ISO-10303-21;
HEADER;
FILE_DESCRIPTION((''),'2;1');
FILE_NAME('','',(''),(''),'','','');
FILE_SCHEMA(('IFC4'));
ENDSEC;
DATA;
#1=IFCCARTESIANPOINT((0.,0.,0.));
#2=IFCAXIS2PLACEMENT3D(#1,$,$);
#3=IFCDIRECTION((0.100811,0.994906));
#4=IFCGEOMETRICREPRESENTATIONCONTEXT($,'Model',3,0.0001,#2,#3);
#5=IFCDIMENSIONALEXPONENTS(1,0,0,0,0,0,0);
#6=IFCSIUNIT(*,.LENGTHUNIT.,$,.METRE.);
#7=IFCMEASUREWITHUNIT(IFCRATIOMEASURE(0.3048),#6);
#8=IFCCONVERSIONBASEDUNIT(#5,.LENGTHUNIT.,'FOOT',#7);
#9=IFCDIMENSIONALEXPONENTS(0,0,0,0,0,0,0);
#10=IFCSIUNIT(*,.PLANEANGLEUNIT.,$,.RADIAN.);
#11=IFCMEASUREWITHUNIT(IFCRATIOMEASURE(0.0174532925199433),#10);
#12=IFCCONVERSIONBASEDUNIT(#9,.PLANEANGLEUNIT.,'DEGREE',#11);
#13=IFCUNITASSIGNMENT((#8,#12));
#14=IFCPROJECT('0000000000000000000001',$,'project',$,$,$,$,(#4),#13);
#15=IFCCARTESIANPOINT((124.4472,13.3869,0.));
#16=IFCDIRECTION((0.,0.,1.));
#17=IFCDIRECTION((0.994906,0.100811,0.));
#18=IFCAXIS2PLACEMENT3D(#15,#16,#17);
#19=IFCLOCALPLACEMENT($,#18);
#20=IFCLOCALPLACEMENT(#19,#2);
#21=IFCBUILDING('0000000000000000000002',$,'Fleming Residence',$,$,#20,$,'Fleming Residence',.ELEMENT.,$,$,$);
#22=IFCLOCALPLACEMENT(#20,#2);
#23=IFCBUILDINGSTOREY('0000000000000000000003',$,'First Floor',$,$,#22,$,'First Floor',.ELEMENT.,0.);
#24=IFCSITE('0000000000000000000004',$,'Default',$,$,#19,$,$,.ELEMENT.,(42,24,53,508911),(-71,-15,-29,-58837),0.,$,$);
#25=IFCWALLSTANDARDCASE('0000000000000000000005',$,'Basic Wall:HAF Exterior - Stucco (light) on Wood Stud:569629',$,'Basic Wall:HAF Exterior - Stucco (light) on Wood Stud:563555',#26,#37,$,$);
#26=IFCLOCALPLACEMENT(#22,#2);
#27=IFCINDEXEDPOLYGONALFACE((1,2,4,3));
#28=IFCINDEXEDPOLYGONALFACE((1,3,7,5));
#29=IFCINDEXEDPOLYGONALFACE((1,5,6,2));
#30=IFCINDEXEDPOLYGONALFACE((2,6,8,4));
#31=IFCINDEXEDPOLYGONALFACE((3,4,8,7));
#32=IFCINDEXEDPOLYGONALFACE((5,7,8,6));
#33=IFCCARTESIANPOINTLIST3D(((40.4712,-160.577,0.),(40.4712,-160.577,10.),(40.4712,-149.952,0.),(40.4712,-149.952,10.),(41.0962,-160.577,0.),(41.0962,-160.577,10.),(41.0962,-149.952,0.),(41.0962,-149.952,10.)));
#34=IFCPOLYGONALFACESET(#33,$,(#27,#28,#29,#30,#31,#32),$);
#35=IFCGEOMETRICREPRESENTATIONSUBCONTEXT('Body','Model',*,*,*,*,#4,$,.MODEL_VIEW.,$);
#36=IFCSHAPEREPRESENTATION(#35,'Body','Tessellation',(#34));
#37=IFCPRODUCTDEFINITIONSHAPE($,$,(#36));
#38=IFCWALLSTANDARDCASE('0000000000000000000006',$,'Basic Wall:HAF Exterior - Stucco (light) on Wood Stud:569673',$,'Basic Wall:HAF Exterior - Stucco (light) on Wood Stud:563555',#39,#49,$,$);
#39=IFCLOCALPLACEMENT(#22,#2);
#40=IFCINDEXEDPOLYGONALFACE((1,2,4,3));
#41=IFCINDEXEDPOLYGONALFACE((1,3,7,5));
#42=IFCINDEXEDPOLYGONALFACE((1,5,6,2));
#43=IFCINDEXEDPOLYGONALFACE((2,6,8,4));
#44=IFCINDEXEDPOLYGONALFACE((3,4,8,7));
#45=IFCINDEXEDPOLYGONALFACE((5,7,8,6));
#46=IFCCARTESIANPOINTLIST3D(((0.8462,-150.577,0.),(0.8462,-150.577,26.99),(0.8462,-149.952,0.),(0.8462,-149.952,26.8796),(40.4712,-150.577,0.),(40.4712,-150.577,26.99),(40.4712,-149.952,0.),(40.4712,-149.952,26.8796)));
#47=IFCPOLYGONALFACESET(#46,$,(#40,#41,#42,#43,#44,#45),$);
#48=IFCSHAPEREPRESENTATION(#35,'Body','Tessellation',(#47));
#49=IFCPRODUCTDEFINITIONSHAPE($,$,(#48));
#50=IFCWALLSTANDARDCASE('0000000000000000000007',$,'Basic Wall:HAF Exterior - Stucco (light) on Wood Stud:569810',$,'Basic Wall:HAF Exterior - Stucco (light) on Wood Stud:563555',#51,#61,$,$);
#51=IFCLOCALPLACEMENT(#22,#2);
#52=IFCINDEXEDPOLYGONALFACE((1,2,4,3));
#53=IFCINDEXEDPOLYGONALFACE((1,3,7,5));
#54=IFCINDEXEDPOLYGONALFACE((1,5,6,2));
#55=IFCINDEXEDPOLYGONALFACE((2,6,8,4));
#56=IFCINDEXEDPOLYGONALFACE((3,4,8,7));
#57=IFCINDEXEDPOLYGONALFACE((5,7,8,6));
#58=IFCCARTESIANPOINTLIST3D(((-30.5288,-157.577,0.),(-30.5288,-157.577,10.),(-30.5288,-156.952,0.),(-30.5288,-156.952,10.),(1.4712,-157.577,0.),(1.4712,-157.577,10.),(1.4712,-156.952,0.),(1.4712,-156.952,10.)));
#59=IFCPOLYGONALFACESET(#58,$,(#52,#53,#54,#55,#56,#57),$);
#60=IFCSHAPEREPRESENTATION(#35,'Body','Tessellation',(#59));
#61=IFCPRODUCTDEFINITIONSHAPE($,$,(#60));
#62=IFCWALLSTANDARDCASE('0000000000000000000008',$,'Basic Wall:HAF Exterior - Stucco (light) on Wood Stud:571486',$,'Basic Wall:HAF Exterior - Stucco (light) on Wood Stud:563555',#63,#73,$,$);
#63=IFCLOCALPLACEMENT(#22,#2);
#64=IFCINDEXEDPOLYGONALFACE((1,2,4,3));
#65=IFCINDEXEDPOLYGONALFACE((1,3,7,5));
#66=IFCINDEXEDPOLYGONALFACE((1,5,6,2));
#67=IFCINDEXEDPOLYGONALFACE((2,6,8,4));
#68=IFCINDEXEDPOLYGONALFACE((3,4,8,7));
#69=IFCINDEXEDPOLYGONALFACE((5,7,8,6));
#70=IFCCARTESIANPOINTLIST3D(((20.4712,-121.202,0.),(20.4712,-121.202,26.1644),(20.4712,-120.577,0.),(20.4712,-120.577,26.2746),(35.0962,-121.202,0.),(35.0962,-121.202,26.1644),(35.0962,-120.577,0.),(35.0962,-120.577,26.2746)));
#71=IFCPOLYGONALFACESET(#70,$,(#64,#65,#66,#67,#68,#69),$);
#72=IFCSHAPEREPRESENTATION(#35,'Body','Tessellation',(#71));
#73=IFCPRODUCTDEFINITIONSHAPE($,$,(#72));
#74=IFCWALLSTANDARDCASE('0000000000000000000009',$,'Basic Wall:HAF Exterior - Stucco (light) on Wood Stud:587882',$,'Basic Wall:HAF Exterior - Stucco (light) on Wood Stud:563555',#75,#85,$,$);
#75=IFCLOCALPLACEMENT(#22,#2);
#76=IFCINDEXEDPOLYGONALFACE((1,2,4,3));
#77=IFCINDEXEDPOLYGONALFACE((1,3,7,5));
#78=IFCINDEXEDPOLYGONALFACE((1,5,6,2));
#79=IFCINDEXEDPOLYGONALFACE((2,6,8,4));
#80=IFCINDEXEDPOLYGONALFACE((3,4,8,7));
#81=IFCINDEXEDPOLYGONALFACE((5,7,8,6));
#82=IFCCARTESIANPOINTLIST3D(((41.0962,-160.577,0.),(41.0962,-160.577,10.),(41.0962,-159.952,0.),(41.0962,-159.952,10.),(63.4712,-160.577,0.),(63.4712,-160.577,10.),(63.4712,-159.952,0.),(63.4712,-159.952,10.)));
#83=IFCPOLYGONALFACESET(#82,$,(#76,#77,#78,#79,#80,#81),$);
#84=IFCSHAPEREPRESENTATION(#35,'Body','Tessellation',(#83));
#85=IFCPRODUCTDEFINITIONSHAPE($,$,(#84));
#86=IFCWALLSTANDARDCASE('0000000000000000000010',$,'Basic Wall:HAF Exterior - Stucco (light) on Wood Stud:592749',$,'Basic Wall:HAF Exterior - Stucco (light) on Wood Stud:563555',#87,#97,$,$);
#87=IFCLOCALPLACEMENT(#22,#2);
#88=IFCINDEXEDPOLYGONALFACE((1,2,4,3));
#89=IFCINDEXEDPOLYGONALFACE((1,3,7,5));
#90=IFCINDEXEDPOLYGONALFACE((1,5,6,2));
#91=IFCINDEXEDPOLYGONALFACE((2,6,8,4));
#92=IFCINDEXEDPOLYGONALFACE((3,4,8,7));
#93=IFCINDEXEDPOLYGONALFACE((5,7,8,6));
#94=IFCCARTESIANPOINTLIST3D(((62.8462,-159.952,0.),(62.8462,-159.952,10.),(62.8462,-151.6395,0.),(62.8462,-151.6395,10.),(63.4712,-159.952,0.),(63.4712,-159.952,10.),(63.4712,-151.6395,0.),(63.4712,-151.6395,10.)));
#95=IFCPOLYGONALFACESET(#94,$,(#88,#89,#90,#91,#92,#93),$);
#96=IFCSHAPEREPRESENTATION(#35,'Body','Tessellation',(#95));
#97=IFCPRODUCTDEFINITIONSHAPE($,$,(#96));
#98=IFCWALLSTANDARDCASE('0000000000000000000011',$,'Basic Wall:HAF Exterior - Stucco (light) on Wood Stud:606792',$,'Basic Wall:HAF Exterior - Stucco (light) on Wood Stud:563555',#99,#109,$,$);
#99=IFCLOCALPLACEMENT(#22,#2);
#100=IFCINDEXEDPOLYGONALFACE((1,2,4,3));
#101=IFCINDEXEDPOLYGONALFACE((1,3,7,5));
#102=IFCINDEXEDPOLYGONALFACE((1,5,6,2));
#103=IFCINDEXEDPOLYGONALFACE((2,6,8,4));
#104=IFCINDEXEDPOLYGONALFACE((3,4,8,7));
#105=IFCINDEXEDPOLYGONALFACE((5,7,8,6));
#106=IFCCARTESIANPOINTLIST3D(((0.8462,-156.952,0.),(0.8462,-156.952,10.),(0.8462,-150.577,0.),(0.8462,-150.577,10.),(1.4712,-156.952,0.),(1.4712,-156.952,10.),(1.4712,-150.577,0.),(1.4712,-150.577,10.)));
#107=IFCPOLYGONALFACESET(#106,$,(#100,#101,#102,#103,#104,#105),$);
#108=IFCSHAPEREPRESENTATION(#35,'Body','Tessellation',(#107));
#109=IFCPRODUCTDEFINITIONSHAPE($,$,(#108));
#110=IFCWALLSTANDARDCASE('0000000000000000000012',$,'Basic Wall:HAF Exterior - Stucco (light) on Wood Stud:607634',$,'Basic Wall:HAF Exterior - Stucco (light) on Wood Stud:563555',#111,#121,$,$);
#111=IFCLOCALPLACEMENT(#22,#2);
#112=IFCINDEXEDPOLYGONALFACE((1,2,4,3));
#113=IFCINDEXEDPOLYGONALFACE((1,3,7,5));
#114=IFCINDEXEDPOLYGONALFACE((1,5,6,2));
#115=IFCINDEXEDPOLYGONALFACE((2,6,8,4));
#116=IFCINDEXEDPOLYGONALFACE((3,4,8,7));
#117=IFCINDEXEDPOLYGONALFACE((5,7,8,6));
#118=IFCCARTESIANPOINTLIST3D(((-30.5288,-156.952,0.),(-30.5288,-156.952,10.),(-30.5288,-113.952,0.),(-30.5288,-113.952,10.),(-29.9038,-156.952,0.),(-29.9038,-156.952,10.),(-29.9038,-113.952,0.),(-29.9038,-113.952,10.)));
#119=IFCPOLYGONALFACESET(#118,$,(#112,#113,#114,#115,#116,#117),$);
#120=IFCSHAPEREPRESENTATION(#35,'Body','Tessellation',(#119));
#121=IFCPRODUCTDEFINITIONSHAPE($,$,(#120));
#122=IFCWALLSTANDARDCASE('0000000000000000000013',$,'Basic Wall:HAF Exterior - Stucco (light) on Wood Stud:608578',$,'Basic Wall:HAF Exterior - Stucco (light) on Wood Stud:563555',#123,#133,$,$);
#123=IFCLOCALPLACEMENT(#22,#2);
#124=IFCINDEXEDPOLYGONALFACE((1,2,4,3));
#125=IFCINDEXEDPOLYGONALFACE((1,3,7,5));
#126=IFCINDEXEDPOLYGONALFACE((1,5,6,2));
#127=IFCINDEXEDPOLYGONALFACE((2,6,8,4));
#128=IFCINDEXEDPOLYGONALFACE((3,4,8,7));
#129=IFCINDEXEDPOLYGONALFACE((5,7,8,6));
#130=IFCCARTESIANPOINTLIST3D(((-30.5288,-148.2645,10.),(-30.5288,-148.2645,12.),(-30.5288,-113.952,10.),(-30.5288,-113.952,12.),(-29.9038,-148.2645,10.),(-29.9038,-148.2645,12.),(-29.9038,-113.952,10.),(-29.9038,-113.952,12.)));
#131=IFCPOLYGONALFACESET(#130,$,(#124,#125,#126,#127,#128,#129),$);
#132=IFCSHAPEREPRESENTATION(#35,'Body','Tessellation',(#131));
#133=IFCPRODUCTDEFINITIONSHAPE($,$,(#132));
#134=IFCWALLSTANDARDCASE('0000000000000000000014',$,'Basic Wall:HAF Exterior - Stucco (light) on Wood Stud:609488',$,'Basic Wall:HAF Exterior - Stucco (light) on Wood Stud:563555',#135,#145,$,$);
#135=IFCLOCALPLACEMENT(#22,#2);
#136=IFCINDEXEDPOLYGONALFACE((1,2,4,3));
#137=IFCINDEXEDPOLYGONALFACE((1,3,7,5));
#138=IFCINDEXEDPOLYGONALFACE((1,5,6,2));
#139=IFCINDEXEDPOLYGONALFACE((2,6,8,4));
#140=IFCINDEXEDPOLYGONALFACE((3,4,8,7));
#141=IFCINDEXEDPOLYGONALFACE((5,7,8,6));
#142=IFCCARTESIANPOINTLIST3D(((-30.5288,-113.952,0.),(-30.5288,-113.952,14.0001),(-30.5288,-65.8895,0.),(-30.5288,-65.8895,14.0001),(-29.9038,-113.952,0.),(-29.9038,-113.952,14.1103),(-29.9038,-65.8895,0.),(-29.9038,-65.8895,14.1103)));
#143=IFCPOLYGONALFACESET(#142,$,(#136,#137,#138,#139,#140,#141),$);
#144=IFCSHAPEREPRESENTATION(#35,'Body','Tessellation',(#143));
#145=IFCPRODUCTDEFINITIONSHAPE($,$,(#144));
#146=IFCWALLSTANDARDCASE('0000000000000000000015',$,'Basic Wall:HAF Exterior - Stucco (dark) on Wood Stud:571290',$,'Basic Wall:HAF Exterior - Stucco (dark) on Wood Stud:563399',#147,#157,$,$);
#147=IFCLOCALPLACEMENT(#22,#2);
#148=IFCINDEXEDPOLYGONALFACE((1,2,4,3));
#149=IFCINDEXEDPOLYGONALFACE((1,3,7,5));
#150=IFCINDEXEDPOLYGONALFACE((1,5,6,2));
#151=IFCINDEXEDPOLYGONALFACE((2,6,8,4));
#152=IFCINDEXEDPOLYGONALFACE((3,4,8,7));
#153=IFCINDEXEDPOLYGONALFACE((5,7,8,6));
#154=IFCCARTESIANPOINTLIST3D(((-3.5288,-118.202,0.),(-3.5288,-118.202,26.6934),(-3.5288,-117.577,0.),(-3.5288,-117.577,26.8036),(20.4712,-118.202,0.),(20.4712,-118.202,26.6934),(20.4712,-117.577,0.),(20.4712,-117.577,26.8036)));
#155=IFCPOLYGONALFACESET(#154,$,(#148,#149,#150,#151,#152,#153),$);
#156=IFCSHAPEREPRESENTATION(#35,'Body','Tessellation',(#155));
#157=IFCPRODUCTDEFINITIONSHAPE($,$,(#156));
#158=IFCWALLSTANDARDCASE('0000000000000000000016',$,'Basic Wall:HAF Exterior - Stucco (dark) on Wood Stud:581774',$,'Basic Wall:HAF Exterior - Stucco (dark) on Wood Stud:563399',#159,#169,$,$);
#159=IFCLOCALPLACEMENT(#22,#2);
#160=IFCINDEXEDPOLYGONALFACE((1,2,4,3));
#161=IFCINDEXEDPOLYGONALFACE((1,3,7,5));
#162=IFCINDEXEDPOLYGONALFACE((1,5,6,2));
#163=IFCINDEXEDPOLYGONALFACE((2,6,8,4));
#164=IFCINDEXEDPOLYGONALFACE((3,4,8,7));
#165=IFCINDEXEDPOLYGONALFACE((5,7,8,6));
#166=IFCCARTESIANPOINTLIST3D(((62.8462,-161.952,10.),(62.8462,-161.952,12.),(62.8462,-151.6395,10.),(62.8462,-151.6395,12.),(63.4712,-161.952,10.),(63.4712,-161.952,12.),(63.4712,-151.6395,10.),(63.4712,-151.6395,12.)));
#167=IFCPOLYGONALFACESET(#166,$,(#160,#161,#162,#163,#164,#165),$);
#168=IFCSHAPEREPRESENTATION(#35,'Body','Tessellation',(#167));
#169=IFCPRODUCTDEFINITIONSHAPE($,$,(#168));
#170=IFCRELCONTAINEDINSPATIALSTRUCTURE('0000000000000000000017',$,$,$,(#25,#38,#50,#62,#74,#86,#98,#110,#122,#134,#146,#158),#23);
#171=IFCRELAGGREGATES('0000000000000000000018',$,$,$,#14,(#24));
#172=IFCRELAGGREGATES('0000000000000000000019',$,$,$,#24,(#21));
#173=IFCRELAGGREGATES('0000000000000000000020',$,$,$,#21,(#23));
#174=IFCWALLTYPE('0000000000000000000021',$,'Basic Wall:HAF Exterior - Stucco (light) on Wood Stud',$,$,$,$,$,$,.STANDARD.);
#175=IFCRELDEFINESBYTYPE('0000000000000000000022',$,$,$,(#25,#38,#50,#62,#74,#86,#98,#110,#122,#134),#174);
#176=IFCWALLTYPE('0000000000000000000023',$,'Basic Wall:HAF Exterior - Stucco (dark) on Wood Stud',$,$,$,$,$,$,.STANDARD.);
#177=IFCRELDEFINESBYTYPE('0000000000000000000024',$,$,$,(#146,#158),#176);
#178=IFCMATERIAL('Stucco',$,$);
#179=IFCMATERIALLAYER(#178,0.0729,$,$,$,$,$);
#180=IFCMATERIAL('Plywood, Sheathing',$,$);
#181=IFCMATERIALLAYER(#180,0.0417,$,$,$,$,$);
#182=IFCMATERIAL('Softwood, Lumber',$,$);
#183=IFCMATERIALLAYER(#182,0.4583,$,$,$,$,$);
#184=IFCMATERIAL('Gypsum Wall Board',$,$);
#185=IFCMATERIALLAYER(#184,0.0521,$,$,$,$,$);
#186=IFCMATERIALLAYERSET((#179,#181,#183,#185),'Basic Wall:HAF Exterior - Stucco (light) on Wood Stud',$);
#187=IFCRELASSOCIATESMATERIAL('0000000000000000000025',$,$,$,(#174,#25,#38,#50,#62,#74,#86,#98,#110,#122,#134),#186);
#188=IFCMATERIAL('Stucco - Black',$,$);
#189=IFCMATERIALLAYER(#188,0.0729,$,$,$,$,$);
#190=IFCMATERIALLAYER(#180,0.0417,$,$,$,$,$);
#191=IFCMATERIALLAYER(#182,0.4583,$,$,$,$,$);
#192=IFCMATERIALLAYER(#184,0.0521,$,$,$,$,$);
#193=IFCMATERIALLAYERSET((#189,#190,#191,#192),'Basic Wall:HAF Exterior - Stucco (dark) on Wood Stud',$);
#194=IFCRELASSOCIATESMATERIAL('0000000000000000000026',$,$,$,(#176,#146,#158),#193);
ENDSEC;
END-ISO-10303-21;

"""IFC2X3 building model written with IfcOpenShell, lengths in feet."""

from ifc_helpers import new_model, entity, si_unit, converted_unit, direction, frame, frame_2d, origin, place, context, subcontext, project, spatial, polyline, rectangle, extrude, clip, bounded_halfspace, material, layer, layer_set, layer_usage, type_object, element, save


model = new_model("IFC2X3")

# Units and contexts
model_context = context("Model", 3, precision=0.0001, world=origin(), true_north=direction((0.100811, 0.994906)))
body_context = subcontext(model_context, "Body", "Model", "MODEL_VIEW")
ifc_project = project(units=[converted_unit("LENGTHUNIT", "FOOT", entity("IfcRatioMeasure", 0.3048), si_unit("LENGTHUNIT", "METRE"), dimensions=[1, 0, 0, 0, 0, 0, 0]), converted_unit("PLANEANGLEUNIT", "DEGREE", entity("IfcRatioMeasure", 0.0174532925199433), si_unit("PLANEANGLEUNIT", "RADIAN"), dimensions=[0, 0, 0, 0, 0, 0, 0])], contexts=[model_context])

# Site, building, storey
site_placement = place(None, frame((124.4472, 13.3869, 0.0), z_axis=(0.0, 0.0, 1.0), x_axis=(0.994906, 0.100811, 0.0)))
site = spatial("IfcSite", under=ifc_project, at=site_placement, Name="Default", CompositionType="ELEMENT", RefLatitude=(42, 24, 53, 508911), RefLongitude=(-71, -15, -29, -58837), RefElevation=0.0)
building_placement = place(site_placement, origin())
building = spatial("IfcBuilding", under=site, at=building_placement, Name="Fleming Residence", LongName="Fleming Residence", CompositionType="ELEMENT")
storey_placement = place(building_placement, origin())
storey = spatial("IfcBuildingStorey", under=building, at=storey_placement, Name="First Floor", LongName="First Floor", CompositionType="ELEMENT", Elevation=0.0)

# Walls
ifc_material_1 = material(Name="Stucco")
ifc_layer_1 = layer(ifc_material_1, 0.0729)
ifc_material_2 = material(Name="Plywood, Sheathing")
ifc_layer_2 = layer(ifc_material_2, 0.0417)
ifc_material_3 = material(Name="Softwood, Lumber")
ifc_layer_3 = layer(ifc_material_3, 0.4583)
ifc_material_4 = material(Name="Gypsum Wall Board")
ifc_layer_4 = layer(ifc_material_4, 0.0521)
ifc_layer_set_1 = layer_set([ifc_layer_1, ifc_layer_2, ifc_layer_3, ifc_layer_4], Name="Basic Wall:HAF Exterior - Stucco (light) on Wood Stud")
ifc_layer_usage_1 = layer_usage(ifc_layer_set_1, "AXIS2", "NEGATIVE", 0.3125)
wall_type_1 = type_object("IfcWallType", Name="Basic Wall:HAF Exterior - Stucco (light) on Wood Stud", PredefinedType="STANDARD", material=ifc_layer_set_1)
wall_1_placement = place(storey_placement, frame((40.7837, -160.577, 0.0), z_axis=(0.0, 0.0, 1.0), x_axis=(0.0, 1.0, 0.0)))
element("IfcWallStandardCase", 1, at=wall_1_placement, inside=storey, type_object=wall_type_1, material=ifc_layer_usage_1, Name="Basic Wall:HAF Exterior - Stucco (light) on Wood Stud:569629", ObjectType="Basic Wall:HAF Exterior - Stucco (light) on Wood Stud:563555", context=body_context, shape_type="SweptSolid", body=[
    extrude(rectangle(XDim=10.625, YDim=0.625, at=frame_2d((5.3125, 0.0), x_axis=(-1.0, 0.0))), origin(), (0.0, 0.0, 1.0), 10.0),
])
ifc_layer_usage_2 = layer_usage(ifc_layer_set_1, "AXIS2", "NEGATIVE", 0.3125)
wall_2_placement = place(storey_placement, frame((41.0962, -150.2645, 0.0), z_axis=(0.0, 0.0, 1.0), x_axis=(-1.0, 0.0, 0.0)))
element("IfcWallStandardCase", 2, at=wall_2_placement, inside=storey, type_object=wall_type_1, material=ifc_layer_usage_2, Name="Basic Wall:HAF Exterior - Stucco (light) on Wood Stud:569673", ObjectType="Basic Wall:HAF Exterior - Stucco (light) on Wood Stud:563555", context=body_context, shape_type="Clipping", body=[
    clip(extrude(rectangle(XDim=39.625, YDim=0.625, at=frame_2d((20.4375, 0.0), x_axis=(-1.0, 0.0))), origin(), (0.0, 0.0, 1.0), 26.99), bounded_halfspace(frame((0.0, -0.3125, 26.8796), z_axis=(0.0, 0.174064, -0.984734), x_axis=(1.0, 0.0, 0.0)), True, frame((0.0, -0.3125, 26.8796)), polyline([(0.0, 0.0), (39.625, 0.0), (40.25, 0.0), (40.25, 0.625), (0.0, 0.625), (0.0, 0.0)]))),
])
ifc_layer_usage_3 = layer_usage(ifc_layer_set_1, "AXIS2", "NEGATIVE", 0.3125)
wall_3_placement = place(storey_placement, frame((1.4712, -157.2645, 0.0), z_axis=(0.0, 0.0, 1.0), x_axis=(-1.0, 0.0, 0.0)))
element("IfcWallStandardCase", 3, at=wall_3_placement, inside=storey, type_object=wall_type_1, material=ifc_layer_usage_3, Name="Basic Wall:HAF Exterior - Stucco (light) on Wood Stud:569810", ObjectType="Basic Wall:HAF Exterior - Stucco (light) on Wood Stud:563555", context=body_context, shape_type="SweptSolid", body=[
    extrude(rectangle(XDim=32.0, YDim=0.625, at=frame_2d((16.0, 0.0), x_axis=(-1.0, 0.0))), origin(), (0.0, 0.0, 1.0), 10.0),
])
ifc_layer_usage_4 = layer_usage(ifc_layer_set_1, "AXIS2", "NEGATIVE", 0.3125)
wall_4_placement = place(storey_placement, frame((20.4712, -120.8895, 0.0)))
element("IfcWallStandardCase", 4, at=wall_4_placement, inside=storey, type_object=wall_type_1, material=ifc_layer_usage_4, Name="Basic Wall:HAF Exterior - Stucco (light) on Wood Stud:571486", ObjectType="Basic Wall:HAF Exterior - Stucco (light) on Wood Stud:563555", context=body_context, shape_type="Clipping", body=[
    clip(extrude(rectangle(XDim=14.625, YDim=0.625, at=frame_2d((7.3125, 0.0), x_axis=(-1.0, 0.0))), origin(), (0.0, 0.0, 1.0), 26.2746), bounded_halfspace(frame((0.0, -0.3125, 26.1644), z_axis=(0.0, 0.173648, -0.984808), x_axis=(-1.0, 0.0, 0.0)), True, frame((0.0, -0.3125, 26.1644)), polyline([(0.0, 0.0), (14.625, 0.0), (14.625, 0.625), (0.0, 0.625), (0.0, 0.0)]))),
])
ifc_layer_usage_5 = layer_usage(ifc_layer_set_1, "AXIS2", "NEGATIVE", 0.3125)
wall_5_placement = place(storey_placement, frame((63.4712, -160.2645, 0.0), z_axis=(0.0, 0.0, 1.0), x_axis=(-1.0, 0.0, 0.0)))
element("IfcWallStandardCase", 5, at=wall_5_placement, inside=storey, type_object=wall_type_1, material=ifc_layer_usage_5, Name="Basic Wall:HAF Exterior - Stucco (light) on Wood Stud:587882", ObjectType="Basic Wall:HAF Exterior - Stucco (light) on Wood Stud:563555", context=body_context, shape_type="SweptSolid", body=[
    extrude(rectangle(XDim=22.375, YDim=0.625, at=frame_2d((11.1875, 0.0), x_axis=(-1.0, 0.0))), origin(), (0.0, 0.0, 1.0), 10.0),
])
ifc_layer_usage_6 = layer_usage(ifc_layer_set_1, "AXIS2", "NEGATIVE", 0.3125)
wall_6_placement = place(storey_placement, frame((63.1587, -151.6395, 0.0), z_axis=(0.0, 0.0, 1.0), x_axis=(0.0, -1.0, 0.0)))
element("IfcWallStandardCase", 6, at=wall_6_placement, inside=storey, type_object=wall_type_1, material=ifc_layer_usage_6, Name="Basic Wall:HAF Exterior - Stucco (light) on Wood Stud:592749", ObjectType="Basic Wall:HAF Exterior - Stucco (light) on Wood Stud:563555", context=body_context, shape_type="SweptSolid", body=[
    extrude(rectangle(XDim=8.3125, YDim=0.625, at=frame_2d((4.1562, 0.0), x_axis=(-1.0, 0.0))), origin(), (0.0, 0.0, 1.0), 10.0),
])
ifc_layer_usage_7 = layer_usage(ifc_layer_set_1, "AXIS2", "NEGATIVE", 0.3125)
wall_7_placement = place(storey_placement, frame((1.1587, -150.577, 0.0), z_axis=(0.0, 0.0, 1.0), x_axis=(0.0, -1.0, 0.0)))
element("IfcWallStandardCase", 7, at=wall_7_placement, inside=storey, type_object=wall_type_1, material=ifc_layer_usage_7, Name="Basic Wall:HAF Exterior - Stucco (light) on Wood Stud:606792", ObjectType="Basic Wall:HAF Exterior - Stucco (light) on Wood Stud:563555", context=body_context, shape_type="SweptSolid", body=[
    extrude(rectangle(XDim=6.375, YDim=0.625, at=frame_2d((3.1875, 0.0), x_axis=(-1.0, 0.0))), origin(), (0.0, 0.0, 1.0), 10.0),
])
ifc_layer_usage_8 = layer_usage(ifc_layer_set_1, "AXIS2", "NEGATIVE", 0.3125)
wall_8_placement = place(storey_placement, frame((-30.2163, -156.952, 0.0), z_axis=(0.0, 0.0, 1.0), x_axis=(0.0, 1.0, 0.0)))
element("IfcWallStandardCase", 8, at=wall_8_placement, inside=storey, type_object=wall_type_1, material=ifc_layer_usage_8, Name="Basic Wall:HAF Exterior - Stucco (light) on Wood Stud:607634", ObjectType="Basic Wall:HAF Exterior - Stucco (light) on Wood Stud:563555", context=body_context, shape_type="SweptSolid", body=[
    extrude(rectangle(XDim=43.0, YDim=0.625, at=frame_2d((21.5, 0.0), x_axis=(-1.0, 0.0))), origin(), (0.0, 0.0, 1.0), 10.0),
])
ifc_layer_usage_9 = layer_usage(ifc_layer_set_1, "AXIS2", "NEGATIVE", 0.3125)
wall_9_placement = place(storey_placement, frame((-30.2163, -148.2645, 10.0), z_axis=(0.0, 0.0, 1.0), x_axis=(0.0, 1.0, 0.0)))
element("IfcWallStandardCase", 9, at=wall_9_placement, inside=storey, type_object=wall_type_1, material=ifc_layer_usage_9, Name="Basic Wall:HAF Exterior - Stucco (light) on Wood Stud:608578", ObjectType="Basic Wall:HAF Exterior - Stucco (light) on Wood Stud:563555", context=body_context, shape_type="SweptSolid", body=[
    extrude(rectangle(XDim=34.3125, YDim=0.625, at=frame_2d((17.1562, 0.0), x_axis=(-1.0, 0.0))), origin(), (0.0, 0.0, 1.0), 2.0),
])
ifc_layer_usage_10 = layer_usage(ifc_layer_set_1, "AXIS2", "NEGATIVE", 0.3125)
wall_10_placement = place(storey_placement, frame((-30.2163, -113.952, 0.0), z_axis=(0.0, 0.0, 1.0), x_axis=(0.0, 1.0, 0.0)))
element("IfcWallStandardCase", 10, at=wall_10_placement, inside=storey, type_object=wall_type_1, material=ifc_layer_usage_10, Name="Basic Wall:HAF Exterior - Stucco (light) on Wood Stud:609488", ObjectType="Basic Wall:HAF Exterior - Stucco (light) on Wood Stud:563555", context=body_context, shape_type="Clipping", body=[
    clip(extrude(rectangle(XDim=48.0625, YDim=0.625, at=frame_2d((24.0312, 0.0), x_axis=(-1.0, 0.0))), origin(), (0.0, 0.0, 1.0), 14.1103), bounded_halfspace(frame((0.0, -0.3125, 14.1103), z_axis=(0.0, -0.173648, -0.984808), x_axis=(-1.0, 0.0, 0.0)), True, frame((0.0, -0.3125, 14.1103)), polyline([(0.0, 0.0), (48.0625, 0.0), (48.0625, 0.625), (0.0, 0.625), (0.0, 0.0)]))),
])
ifc_material_5 = material(Name="Stucco - Black")
ifc_layer_5 = layer(ifc_material_5, 0.0729)
ifc_layer_6 = layer(ifc_material_2, 0.0417)
ifc_layer_7 = layer(ifc_material_3, 0.4583)
ifc_layer_8 = layer(ifc_material_4, 0.0521)
ifc_layer_set_2 = layer_set([ifc_layer_5, ifc_layer_6, ifc_layer_7, ifc_layer_8], Name="Basic Wall:HAF Exterior - Stucco (dark) on Wood Stud")
ifc_layer_usage_11 = layer_usage(ifc_layer_set_2, "AXIS2", "NEGATIVE", 0.3125)
wall_type_2 = type_object("IfcWallType", Name="Basic Wall:HAF Exterior - Stucco (dark) on Wood Stud", PredefinedType="STANDARD", material=ifc_layer_set_2)
wall_11_placement = place(storey_placement, frame((-3.5288, -117.8895, 0.0)))
element("IfcWallStandardCase", 11, at=wall_11_placement, inside=storey, type_object=wall_type_2, material=ifc_layer_usage_11, Name="Basic Wall:HAF Exterior - Stucco (dark) on Wood Stud:571290", ObjectType="Basic Wall:HAF Exterior - Stucco (dark) on Wood Stud:563399", context=body_context, shape_type="Clipping", body=[
    clip(extrude(rectangle(XDim=24.0, YDim=0.625, at=frame_2d((12.0, 0.0), x_axis=(-1.0, 0.0))), origin(), (0.0, 0.0, 1.0), 26.8036), bounded_halfspace(frame((0.0, -0.3125, 26.6934), z_axis=(0.0, 0.173648, -0.984808), x_axis=(-1.0, 0.0, 0.0)), True, frame((0.0, -0.3125, 26.6934)), polyline([(0.0, 0.0), (23.375, 0.0), (24.0, 0.0), (24.0, 0.625), (0.0, 0.625), (0.0, 0.0)]))),
])
ifc_layer_usage_12 = layer_usage(ifc_layer_set_2, "AXIS2", "NEGATIVE", 0.3125)
wall_12_placement = place(storey_placement, frame((63.1587, -151.6395, 10.0), z_axis=(0.0, 0.0, 1.0), x_axis=(0.0, -1.0, 0.0)))
element("IfcWallStandardCase", 12, at=wall_12_placement, inside=storey, type_object=wall_type_2, material=ifc_layer_usage_12, Name="Basic Wall:HAF Exterior - Stucco (dark) on Wood Stud:581774", ObjectType="Basic Wall:HAF Exterior - Stucco (dark) on Wood Stud:563399", context=body_context, shape_type="SweptSolid", body=[
    extrude(rectangle(XDim=10.3125, YDim=0.625, at=frame_2d((5.1562, 0.0), x_axis=(-1.0, 0.0))), origin(), (0.0, 0.0, 1.0), 2.0),
])

save(model, "model.ifc")
